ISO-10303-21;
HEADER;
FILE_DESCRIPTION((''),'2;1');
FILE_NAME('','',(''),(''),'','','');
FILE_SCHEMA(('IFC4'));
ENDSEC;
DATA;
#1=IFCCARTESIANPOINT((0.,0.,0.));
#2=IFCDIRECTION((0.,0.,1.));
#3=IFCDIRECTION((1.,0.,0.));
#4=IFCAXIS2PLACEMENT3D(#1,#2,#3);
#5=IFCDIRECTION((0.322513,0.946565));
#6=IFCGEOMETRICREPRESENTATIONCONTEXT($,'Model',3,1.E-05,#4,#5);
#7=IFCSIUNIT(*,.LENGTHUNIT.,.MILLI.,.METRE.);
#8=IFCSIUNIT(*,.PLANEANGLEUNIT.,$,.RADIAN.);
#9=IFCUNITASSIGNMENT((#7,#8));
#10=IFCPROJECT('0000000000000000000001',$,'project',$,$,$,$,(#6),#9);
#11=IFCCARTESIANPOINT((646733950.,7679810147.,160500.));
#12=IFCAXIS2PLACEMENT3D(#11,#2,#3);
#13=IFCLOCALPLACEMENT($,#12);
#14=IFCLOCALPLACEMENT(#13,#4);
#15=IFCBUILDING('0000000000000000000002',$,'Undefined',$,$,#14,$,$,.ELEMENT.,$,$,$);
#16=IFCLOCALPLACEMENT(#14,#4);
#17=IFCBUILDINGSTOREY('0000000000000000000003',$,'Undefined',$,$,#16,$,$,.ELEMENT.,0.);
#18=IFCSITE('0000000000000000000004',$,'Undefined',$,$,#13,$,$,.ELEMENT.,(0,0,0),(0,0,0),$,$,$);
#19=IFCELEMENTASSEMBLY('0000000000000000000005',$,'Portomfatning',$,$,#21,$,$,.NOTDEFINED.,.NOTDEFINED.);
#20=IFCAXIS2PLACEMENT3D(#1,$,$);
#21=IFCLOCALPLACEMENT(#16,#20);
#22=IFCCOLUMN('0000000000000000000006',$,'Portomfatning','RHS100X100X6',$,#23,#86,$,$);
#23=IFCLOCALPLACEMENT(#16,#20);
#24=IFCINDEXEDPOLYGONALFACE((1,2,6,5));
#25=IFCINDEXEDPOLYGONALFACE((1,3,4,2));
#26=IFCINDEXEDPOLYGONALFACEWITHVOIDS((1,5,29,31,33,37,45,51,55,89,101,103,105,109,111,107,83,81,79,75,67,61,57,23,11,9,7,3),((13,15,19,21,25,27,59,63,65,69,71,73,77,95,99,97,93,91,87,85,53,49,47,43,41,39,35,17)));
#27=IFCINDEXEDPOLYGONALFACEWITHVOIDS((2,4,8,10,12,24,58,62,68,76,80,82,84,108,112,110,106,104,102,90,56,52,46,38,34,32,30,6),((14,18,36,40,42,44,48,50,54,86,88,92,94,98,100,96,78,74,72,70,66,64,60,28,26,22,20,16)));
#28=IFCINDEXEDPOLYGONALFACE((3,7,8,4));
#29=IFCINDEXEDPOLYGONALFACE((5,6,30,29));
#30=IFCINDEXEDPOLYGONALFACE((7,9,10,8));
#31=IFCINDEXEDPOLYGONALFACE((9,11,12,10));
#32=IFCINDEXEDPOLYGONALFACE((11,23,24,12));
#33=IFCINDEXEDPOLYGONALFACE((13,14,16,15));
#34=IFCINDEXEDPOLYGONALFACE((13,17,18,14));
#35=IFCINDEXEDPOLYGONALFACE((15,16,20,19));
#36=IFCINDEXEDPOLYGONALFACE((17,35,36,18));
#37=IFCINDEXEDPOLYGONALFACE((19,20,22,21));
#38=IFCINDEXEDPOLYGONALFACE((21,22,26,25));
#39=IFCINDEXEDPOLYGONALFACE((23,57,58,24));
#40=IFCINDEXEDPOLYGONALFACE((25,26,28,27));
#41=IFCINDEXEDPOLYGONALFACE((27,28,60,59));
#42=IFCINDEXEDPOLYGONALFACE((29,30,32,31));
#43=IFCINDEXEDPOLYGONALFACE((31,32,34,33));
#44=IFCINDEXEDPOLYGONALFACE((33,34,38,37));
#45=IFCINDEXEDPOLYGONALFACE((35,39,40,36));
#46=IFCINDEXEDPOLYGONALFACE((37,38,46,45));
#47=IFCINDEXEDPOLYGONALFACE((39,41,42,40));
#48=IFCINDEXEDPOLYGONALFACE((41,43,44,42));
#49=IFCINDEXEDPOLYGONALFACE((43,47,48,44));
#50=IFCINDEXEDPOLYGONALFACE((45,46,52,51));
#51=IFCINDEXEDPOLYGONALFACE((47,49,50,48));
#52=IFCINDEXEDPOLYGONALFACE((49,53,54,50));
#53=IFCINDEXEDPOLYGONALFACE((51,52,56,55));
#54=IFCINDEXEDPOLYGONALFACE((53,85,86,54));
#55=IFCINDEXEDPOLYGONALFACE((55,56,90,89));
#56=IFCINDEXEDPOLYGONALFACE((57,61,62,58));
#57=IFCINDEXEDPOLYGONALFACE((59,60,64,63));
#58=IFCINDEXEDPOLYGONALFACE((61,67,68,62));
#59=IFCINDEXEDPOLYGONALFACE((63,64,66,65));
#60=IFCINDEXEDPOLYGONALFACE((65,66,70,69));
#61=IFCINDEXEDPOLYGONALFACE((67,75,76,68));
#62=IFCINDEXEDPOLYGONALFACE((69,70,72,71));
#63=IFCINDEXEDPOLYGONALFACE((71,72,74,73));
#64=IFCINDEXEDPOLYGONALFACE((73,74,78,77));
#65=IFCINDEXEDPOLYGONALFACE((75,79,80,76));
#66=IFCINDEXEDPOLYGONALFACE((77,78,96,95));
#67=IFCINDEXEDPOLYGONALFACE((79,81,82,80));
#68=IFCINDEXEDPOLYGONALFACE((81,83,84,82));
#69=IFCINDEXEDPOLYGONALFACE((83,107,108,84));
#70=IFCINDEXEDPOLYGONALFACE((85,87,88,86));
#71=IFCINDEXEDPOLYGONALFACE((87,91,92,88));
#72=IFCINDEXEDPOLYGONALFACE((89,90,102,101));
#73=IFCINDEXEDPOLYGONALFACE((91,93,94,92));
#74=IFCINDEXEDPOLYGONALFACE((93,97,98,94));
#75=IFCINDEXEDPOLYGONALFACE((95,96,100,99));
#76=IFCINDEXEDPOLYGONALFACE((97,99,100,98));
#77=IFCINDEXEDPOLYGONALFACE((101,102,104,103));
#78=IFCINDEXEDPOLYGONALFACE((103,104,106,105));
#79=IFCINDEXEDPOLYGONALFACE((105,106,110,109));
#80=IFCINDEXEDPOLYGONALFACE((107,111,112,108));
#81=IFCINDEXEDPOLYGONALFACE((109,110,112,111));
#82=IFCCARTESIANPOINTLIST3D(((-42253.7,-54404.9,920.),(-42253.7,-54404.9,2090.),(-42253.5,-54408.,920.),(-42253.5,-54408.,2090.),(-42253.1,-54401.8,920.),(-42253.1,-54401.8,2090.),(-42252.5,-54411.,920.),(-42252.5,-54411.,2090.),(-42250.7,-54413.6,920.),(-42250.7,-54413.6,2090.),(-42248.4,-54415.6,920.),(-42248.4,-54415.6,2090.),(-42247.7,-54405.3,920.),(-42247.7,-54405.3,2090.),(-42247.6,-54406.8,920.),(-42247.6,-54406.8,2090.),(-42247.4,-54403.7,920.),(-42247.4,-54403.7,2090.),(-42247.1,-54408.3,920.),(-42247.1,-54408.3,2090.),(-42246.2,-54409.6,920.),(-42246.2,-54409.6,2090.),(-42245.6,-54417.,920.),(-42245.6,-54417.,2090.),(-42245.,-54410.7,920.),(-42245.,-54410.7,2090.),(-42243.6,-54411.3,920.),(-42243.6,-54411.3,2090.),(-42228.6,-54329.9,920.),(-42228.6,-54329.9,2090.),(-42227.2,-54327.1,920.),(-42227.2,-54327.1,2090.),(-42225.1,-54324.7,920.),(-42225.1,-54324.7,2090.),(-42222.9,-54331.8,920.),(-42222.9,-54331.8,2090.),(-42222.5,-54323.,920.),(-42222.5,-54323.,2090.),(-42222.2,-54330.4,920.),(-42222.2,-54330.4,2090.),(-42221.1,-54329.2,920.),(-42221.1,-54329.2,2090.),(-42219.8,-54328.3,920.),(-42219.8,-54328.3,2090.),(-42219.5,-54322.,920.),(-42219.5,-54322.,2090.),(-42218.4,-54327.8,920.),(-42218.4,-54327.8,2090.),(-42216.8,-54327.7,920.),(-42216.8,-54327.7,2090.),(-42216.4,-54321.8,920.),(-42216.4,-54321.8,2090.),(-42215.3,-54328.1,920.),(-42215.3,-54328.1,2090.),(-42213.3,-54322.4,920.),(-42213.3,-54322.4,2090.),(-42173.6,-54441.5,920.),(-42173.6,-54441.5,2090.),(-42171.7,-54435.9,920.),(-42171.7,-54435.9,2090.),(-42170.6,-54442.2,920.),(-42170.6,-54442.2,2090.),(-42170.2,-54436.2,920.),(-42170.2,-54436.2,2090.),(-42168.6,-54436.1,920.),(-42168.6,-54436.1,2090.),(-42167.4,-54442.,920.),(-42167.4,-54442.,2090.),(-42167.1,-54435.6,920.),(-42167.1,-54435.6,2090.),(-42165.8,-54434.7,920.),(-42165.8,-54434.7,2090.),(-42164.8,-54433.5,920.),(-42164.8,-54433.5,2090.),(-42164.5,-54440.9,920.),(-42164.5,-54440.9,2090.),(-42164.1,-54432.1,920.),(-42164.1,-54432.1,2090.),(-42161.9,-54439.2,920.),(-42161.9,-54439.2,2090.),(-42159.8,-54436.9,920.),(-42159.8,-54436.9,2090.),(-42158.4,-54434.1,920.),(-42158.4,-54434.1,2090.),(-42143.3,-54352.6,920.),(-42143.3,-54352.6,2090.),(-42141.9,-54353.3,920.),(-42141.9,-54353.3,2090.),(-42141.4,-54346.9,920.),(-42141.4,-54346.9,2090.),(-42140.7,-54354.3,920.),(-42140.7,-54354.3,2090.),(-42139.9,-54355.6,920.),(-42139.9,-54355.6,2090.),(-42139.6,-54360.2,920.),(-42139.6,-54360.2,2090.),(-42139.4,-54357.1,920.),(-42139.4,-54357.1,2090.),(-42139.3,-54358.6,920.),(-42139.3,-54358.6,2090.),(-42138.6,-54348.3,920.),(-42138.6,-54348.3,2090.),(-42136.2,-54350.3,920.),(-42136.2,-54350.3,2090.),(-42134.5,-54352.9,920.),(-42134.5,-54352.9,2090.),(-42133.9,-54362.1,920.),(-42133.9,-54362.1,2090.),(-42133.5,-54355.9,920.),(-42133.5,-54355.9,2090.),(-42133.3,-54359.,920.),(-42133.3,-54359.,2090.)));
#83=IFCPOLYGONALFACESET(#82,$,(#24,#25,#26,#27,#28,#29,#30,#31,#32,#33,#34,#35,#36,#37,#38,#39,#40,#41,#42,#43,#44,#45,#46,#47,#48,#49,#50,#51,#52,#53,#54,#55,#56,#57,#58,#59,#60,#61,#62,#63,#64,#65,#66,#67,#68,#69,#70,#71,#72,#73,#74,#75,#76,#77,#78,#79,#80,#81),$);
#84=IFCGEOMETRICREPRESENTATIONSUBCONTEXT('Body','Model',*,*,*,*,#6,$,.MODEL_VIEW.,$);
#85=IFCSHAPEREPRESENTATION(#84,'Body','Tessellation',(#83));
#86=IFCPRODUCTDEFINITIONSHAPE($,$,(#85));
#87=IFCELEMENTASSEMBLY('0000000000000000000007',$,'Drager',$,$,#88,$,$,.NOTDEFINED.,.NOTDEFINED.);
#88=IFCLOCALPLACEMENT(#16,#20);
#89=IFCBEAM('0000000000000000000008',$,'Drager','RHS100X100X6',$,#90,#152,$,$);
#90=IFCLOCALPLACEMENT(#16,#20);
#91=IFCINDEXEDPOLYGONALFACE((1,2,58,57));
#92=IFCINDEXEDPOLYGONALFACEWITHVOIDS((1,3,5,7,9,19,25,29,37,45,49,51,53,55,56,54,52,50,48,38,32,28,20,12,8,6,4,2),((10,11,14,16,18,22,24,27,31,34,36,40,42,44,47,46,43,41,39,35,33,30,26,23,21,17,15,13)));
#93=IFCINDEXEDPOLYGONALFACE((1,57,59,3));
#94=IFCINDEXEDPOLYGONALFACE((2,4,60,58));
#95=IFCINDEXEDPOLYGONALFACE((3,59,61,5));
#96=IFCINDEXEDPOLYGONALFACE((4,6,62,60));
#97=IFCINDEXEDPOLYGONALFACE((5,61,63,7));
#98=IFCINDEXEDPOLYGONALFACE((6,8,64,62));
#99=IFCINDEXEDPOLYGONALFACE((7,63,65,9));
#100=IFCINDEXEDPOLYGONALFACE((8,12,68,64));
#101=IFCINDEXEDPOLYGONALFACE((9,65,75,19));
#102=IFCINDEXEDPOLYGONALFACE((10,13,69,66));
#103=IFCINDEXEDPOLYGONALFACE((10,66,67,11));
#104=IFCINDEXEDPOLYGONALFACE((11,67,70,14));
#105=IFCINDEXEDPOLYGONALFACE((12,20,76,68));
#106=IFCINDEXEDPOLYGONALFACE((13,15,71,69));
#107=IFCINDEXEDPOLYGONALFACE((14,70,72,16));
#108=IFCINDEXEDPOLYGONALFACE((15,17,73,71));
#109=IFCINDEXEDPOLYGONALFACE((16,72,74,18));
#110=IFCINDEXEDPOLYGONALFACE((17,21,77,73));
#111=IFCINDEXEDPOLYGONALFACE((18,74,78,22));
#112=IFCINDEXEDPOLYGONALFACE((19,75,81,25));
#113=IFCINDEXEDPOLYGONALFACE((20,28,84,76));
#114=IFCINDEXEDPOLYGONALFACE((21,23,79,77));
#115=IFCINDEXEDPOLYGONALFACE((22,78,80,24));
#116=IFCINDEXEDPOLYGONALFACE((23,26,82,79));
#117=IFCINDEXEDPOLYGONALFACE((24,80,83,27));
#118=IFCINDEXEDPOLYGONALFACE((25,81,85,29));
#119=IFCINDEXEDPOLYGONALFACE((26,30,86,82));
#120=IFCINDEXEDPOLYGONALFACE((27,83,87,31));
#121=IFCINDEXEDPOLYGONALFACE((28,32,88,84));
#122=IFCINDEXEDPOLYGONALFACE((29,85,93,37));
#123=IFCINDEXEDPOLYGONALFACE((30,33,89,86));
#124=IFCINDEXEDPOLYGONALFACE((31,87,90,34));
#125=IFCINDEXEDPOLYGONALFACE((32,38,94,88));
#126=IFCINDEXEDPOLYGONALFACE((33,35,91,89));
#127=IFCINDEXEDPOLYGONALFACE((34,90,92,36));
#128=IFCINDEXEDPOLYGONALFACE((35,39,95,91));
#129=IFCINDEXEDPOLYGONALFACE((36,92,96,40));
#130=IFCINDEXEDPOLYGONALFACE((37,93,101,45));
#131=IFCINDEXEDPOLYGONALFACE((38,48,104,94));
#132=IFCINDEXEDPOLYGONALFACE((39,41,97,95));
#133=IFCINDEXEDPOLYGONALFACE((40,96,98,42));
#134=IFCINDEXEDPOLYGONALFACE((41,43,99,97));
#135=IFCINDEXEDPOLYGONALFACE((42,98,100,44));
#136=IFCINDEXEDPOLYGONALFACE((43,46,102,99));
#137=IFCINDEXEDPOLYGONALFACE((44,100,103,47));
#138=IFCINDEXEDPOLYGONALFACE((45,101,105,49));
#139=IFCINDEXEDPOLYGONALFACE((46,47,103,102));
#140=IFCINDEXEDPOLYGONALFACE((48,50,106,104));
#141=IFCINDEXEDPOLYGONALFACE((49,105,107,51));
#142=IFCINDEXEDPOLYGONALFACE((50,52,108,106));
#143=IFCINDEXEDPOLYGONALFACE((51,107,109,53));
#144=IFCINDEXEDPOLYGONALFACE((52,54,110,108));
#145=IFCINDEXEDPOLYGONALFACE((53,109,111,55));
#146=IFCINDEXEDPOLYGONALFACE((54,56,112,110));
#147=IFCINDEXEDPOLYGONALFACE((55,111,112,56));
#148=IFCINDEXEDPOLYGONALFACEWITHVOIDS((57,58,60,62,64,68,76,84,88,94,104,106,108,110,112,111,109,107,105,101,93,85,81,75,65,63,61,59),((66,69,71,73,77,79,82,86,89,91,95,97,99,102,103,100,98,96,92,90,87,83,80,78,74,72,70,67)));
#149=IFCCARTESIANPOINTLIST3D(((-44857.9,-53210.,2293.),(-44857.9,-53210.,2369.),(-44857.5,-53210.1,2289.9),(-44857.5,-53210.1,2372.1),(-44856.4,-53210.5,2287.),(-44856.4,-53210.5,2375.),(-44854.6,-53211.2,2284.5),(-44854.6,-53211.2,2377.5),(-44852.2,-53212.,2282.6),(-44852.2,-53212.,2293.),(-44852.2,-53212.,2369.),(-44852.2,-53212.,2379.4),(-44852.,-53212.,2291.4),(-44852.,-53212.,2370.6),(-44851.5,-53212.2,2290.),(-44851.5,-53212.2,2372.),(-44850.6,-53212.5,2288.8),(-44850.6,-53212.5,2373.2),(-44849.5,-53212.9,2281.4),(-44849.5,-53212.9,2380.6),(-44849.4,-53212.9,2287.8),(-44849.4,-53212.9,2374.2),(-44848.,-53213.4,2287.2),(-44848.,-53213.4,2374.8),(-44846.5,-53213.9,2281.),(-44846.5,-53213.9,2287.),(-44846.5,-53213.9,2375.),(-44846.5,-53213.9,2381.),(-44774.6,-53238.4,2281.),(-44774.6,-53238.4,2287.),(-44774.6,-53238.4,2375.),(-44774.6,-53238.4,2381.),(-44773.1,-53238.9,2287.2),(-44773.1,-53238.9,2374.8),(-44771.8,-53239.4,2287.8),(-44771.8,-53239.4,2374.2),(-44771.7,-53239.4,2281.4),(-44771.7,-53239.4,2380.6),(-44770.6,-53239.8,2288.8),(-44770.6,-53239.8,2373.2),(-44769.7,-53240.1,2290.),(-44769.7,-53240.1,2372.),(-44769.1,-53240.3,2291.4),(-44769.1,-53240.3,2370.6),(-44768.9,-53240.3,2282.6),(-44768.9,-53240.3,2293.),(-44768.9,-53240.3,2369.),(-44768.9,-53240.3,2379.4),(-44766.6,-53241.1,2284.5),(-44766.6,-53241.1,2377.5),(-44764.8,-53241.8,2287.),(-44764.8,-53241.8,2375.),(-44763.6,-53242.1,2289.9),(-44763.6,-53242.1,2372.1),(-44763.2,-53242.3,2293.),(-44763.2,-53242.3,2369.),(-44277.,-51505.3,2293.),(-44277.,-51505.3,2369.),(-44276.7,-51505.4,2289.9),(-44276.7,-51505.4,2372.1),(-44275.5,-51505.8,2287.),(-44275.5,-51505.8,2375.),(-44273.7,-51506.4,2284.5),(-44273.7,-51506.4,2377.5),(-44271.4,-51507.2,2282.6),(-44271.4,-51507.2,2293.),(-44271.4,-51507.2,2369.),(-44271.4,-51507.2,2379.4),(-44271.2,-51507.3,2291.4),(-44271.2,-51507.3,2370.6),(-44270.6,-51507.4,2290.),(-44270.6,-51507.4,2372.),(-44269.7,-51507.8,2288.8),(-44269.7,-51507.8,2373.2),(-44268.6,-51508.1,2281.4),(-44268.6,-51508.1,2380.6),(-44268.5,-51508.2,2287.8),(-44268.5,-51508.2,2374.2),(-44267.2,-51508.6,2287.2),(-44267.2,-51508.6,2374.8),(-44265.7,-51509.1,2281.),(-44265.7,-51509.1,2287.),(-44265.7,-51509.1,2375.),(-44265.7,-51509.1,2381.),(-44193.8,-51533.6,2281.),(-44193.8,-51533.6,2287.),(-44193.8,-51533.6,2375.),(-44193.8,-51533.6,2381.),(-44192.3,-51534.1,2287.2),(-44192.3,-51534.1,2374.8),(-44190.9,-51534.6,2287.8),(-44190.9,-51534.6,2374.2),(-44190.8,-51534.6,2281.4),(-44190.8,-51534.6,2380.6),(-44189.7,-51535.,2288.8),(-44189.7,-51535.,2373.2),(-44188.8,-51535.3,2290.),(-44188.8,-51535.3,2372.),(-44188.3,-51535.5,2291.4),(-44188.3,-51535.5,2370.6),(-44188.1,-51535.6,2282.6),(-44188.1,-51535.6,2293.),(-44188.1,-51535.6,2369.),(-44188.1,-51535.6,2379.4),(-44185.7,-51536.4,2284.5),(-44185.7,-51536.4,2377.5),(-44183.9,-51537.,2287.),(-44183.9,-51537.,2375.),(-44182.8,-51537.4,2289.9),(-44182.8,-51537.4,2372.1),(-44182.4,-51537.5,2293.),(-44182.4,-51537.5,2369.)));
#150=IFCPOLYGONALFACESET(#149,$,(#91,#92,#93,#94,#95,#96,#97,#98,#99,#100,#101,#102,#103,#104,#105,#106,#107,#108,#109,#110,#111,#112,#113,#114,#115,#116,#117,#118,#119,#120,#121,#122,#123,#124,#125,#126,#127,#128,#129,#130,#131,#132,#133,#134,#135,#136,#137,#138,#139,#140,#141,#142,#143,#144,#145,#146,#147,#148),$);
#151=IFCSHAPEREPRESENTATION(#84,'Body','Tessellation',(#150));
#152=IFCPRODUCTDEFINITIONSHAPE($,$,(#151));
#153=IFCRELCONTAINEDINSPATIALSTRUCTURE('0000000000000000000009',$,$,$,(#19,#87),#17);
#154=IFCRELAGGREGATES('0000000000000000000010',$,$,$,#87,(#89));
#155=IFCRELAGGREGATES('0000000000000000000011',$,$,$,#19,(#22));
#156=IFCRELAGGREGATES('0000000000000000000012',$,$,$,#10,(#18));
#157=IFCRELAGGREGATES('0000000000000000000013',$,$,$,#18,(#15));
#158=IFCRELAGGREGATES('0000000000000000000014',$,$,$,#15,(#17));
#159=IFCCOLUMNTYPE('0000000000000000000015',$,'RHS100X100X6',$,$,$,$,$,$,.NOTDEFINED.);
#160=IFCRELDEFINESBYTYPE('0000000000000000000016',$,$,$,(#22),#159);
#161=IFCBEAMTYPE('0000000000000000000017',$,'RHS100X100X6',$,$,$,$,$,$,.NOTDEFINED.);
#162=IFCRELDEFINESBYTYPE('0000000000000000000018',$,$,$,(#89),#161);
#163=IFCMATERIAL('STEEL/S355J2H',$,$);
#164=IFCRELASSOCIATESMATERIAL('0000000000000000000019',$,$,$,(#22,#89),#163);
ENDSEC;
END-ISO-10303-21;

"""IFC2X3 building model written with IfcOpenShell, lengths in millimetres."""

from ifc_helpers import new_model, si_unit, direction, frame, origin_with_axes, origin_2d_with_axis, place, context, subcontext, project, spatial, hollow_rectangle, extrude, clip, halfspace, material, type_object, element, aggregate, save


model = new_model("IFC2X3")

# Units and contexts
model_context = context("Model", 3, precision=1e-05, world=origin_with_axes(), true_north=direction((0.322513, 0.946565)))
body_context = subcontext(model_context, "Body", "Model", "MODEL_VIEW")
ifc_project = project(units=[si_unit("LENGTHUNIT", "METRE", prefix="MILLI"), si_unit("PLANEANGLEUNIT", "RADIAN")], contexts=[model_context])

# Site, building, storey
site_placement = place(None, frame((646733950.0, 7679810147.0, 160500.0), z_axis=(0.0, 0.0, 1.0), x_axis=(1.0, 0.0, 0.0)))
site = spatial("IfcSite", under=ifc_project, at=site_placement, Name="Undefined", CompositionType="ELEMENT", RefLatitude=(0, 0, 0), RefLongitude=(0, 0, 0))
building_placement = place(site_placement, origin_with_axes())
building = spatial("IfcBuilding", under=site, at=building_placement, Name="Undefined", CompositionType="ELEMENT")
storey_placement = place(building_placement, origin_with_axes())
storey = spatial("IfcBuildingStorey", under=building, at=storey_placement, Name="Undefined", CompositionType="ELEMENT", Elevation=0.0)

# Element assembly, column
ifc_material_1 = material(Name="STEEL/S355J2H")
column_type = type_object("IfcColumnType", Name="RHS100X100X6", PredefinedType="NOTDEFINED")
assembly_1_placement = place(storey_placement, origin_with_axes())
assembly_1 = element("IfcElementAssembly", 1, at=assembly_1_placement, inside=storey, Name="Portomfatning", AssemblyPlace="NOTDEFINED", PredefinedType="NOTDEFINED")
column_1_placement = place(assembly_1_placement, frame((-42193.5, -54382.0, 910.0), z_axis=(0.0, 0.0, 1.0), x_axis=(-0.946565, 0.322513, 0.0)))
column_1 = element("IfcColumn", 2, at=column_1_placement, type_object=column_type, material=ifc_material_1, Name="Portomfatning", Description="RHS100X100X6", context=body_context, shape_type="Clipping", body=[
    clip(clip(extrude(hollow_rectangle(XDim=100.0, YDim=100.0, WallThickness=6.0, InnerFilletRadius=6.0, OuterFilletRadius=12.0, at=origin_2d_with_axis()), frame((0.0, 0.0, 1190.0), z_axis=(0.0, 0.0, -1.0), x_axis=(0.0, 1.0, 0.0)), (0.0, 0.0, 1.0), 1190.0), halfspace(frame((-50.0, 0.0, 1180.0), z_axis=(0.0, 0.0, -1.0), x_axis=(0.0, -1.0, 0.0)), True)), halfspace(frame((-50.0, 0.0, 10.0), z_axis=(0.0, 0.0, 1.0), x_axis=(0.0, 1.0, 0.0)), True)),
])

# Element assembly, beam
assembly_2_placement = place(storey_placement, origin_with_axes())
assembly_2 = element("IfcElementAssembly", 3, at=assembly_2_placement, inside=storey, Name="Drager", AssemblyPlace="NOTDEFINED", PredefinedType="NOTDEFINED")
beam_type_1 = type_object("IfcBeamType", Name="RHS100X100X6", PredefinedType="NOTDEFINED")
beam_1_placement = place(assembly_2_placement, frame((-44229.7, -51521.4, 2331.0), z_axis=(0.0, 0.0, 1.0), x_axis=(-0.322513, -0.946565, 0.0)))
beam_1 = element("IfcBeam", 4, at=beam_1_placement, type_object=beam_type_1, material=ifc_material_1, Name="Drager", Description="RHS100X100X6", context=body_context, shape_type="SweptSolid", body=[
    extrude(hollow_rectangle(XDim=100.0, YDim=100.0, WallThickness=6.0, InnerFilletRadius=6.0, OuterFilletRadius=12.0, at=origin_2d_with_axis()), frame((1801.0, 0.0, 0.0), z_axis=(-1.0, 0.0, 0.0), x_axis=(0.0, -1.0, 0.0)), (0.0, 0.0, 1.0), 1801.0),
])
aggregate(assembly_2, [beam_1])

aggregate(assembly_1, [column_1])

save(model, "model.ifc")
